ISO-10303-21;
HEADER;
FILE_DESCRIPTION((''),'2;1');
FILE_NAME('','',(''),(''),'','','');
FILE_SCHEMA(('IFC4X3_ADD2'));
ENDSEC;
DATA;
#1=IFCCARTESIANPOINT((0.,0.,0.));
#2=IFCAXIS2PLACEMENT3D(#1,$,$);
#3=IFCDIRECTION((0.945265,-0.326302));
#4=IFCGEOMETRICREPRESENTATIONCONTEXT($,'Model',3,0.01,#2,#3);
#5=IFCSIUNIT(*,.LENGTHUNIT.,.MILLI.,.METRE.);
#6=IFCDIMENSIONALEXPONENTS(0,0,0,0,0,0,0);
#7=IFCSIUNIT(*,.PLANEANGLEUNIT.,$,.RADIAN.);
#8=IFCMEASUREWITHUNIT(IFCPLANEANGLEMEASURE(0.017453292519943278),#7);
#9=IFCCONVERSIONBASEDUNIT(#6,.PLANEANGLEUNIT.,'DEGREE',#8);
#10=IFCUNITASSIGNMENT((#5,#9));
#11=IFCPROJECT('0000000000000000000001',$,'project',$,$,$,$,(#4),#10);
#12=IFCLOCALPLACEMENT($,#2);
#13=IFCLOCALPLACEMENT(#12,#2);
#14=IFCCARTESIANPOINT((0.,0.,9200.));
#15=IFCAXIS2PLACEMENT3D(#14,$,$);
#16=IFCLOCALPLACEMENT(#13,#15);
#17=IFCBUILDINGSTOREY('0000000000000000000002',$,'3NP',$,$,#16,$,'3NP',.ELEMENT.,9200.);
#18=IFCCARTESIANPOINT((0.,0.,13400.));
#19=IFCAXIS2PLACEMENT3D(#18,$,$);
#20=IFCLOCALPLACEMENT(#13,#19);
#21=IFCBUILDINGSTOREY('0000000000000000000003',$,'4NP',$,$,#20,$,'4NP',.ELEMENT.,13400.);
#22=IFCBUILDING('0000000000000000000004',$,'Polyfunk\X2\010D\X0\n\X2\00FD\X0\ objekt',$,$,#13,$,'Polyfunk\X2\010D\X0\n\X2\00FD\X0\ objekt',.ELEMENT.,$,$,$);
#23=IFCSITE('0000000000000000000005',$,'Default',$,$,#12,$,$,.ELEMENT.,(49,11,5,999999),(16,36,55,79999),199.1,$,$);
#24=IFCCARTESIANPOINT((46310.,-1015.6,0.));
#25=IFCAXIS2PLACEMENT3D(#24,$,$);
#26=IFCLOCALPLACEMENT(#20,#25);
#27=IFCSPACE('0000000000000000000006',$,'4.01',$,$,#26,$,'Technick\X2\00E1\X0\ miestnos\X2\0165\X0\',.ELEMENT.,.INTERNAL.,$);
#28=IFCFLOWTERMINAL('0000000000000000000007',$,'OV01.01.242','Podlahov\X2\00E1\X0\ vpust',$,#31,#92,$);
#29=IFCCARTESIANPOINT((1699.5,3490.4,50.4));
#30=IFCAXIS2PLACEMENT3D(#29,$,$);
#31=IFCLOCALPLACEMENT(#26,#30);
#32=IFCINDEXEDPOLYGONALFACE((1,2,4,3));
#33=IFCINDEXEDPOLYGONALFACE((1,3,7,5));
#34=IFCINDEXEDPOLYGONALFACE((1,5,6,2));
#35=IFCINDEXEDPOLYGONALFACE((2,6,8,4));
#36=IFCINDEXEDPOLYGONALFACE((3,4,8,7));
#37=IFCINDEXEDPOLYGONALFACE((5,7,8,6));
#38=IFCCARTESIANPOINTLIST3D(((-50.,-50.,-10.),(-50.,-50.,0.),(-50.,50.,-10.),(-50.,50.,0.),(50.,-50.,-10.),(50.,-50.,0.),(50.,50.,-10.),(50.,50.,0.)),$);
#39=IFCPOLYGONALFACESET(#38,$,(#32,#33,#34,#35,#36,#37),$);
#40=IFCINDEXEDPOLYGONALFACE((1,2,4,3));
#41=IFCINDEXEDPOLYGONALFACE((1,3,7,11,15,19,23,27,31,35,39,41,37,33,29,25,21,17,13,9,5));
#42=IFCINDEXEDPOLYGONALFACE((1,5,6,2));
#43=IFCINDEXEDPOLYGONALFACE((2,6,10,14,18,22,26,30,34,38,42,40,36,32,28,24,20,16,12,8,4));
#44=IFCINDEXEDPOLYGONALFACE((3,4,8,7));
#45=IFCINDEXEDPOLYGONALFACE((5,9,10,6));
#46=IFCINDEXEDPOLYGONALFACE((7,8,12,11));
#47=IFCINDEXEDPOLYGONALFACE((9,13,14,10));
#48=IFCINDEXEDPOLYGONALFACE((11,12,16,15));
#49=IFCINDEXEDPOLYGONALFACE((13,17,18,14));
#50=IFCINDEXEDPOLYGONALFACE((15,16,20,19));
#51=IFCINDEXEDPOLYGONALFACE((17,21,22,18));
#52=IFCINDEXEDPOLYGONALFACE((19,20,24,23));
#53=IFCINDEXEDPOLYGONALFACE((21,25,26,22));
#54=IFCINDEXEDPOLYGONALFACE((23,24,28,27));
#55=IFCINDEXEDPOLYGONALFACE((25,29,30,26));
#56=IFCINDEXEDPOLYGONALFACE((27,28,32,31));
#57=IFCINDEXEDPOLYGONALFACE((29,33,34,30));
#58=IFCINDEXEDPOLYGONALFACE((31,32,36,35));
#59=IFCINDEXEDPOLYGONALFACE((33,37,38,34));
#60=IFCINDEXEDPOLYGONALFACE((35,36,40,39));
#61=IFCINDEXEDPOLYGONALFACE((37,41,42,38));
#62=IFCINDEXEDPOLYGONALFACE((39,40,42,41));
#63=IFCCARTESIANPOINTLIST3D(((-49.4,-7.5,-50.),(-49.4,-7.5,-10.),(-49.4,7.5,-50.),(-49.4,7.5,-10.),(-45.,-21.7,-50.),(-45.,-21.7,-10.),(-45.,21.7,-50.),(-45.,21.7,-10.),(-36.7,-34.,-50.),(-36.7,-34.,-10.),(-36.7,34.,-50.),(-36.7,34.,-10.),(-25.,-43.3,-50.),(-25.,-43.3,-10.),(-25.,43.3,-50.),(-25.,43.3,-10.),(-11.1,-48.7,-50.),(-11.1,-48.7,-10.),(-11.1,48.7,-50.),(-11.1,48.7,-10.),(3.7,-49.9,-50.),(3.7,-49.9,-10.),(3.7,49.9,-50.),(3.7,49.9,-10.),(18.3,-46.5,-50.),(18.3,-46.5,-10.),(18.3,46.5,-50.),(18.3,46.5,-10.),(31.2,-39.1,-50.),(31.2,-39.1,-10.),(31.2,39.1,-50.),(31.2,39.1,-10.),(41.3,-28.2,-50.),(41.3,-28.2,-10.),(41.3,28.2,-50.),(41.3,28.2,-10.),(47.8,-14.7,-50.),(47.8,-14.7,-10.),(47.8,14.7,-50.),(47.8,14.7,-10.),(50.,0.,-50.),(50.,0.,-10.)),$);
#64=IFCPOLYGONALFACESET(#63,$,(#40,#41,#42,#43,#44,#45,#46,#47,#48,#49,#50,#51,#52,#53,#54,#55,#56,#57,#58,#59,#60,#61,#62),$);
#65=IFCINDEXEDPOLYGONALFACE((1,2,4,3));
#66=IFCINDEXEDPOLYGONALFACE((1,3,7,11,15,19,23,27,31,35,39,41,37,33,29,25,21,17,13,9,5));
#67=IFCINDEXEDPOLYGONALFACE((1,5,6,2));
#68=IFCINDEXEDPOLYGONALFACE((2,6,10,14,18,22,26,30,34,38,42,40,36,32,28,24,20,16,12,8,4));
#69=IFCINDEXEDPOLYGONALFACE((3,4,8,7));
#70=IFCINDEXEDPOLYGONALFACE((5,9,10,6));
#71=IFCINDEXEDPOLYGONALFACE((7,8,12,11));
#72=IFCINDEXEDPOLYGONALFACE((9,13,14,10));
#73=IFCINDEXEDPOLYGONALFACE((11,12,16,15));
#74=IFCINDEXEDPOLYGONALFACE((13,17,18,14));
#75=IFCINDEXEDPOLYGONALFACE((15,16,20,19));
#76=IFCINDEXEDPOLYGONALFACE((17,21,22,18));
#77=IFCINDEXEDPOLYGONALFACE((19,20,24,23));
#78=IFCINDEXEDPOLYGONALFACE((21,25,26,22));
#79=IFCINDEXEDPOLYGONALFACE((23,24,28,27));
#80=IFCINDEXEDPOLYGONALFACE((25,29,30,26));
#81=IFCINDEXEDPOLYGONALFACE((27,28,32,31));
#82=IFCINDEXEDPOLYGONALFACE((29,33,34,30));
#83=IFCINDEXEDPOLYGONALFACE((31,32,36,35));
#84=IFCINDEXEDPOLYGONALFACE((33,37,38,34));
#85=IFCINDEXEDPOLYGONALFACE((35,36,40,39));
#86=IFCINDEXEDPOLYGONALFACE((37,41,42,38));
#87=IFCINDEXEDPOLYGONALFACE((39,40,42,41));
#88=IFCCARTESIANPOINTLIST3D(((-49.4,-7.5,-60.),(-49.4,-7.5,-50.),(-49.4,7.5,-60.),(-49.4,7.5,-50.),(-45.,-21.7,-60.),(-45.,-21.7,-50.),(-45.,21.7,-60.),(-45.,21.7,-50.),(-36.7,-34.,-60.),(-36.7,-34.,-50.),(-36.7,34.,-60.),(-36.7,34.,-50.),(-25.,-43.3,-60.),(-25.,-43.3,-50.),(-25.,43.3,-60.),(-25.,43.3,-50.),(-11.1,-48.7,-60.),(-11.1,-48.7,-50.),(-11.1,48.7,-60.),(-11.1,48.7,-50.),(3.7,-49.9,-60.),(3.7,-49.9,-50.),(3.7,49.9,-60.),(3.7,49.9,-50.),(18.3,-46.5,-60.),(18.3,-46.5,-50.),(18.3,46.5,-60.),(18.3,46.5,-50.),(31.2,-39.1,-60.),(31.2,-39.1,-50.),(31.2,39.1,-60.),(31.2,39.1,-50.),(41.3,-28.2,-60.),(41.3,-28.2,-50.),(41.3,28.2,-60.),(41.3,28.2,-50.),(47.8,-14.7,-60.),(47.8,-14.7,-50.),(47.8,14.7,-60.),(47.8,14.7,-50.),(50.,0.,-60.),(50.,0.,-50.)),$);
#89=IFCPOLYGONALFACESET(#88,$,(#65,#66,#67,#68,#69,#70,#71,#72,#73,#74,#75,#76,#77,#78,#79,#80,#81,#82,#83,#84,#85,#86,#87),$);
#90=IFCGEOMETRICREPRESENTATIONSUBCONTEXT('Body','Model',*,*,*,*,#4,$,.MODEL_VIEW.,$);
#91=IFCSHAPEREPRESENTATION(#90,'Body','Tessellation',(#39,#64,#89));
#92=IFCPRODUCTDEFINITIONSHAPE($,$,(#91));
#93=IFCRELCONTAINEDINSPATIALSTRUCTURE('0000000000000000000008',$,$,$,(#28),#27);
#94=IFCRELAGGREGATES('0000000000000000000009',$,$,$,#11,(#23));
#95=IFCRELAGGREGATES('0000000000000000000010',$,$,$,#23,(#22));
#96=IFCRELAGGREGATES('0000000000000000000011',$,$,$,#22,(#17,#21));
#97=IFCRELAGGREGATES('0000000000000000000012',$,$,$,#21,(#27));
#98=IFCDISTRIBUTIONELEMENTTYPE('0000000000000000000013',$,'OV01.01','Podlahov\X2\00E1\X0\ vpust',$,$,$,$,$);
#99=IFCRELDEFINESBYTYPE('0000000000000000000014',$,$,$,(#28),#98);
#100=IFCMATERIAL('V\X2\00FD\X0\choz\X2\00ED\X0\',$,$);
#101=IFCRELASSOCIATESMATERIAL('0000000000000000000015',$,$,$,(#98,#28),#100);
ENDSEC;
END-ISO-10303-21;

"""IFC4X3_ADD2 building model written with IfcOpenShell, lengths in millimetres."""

from ifc_helpers import new_model, entity, si_unit, converted_unit, direction, frame, frame_2d, origin, place, context, subcontext, project, spatial, rectangle, circle, extrude, source, transform, mapped, material, type_object, type_shapes, element, save


model = new_model("IFC4X3_ADD2")

# Units and contexts
model_context = context("Model", 3, precision=0.01, world=origin(), true_north=direction((0.945265, -0.326302)))
body_context = subcontext(model_context, "Body", "Model", "MODEL_VIEW")
ifc_project = project(units=[si_unit("LENGTHUNIT", "METRE", prefix="MILLI"), converted_unit("PLANEANGLEUNIT", "DEGREE", entity("IfcPlaneAngleMeasure", 0.017453292519943278), si_unit("PLANEANGLEUNIT", "RADIAN"), dimensions=[0, 0, 0, 0, 0, 0, 0])], contexts=[model_context])

# Site, building, storey
site_placement = place(None, origin())
site = spatial("IfcSite", under=ifc_project, at=site_placement, Name="Default", CompositionType="ELEMENT", RefLatitude=(49, 11, 5, 999999), RefLongitude=(16, 36, 55, 79999), RefElevation=199.1)
building_placement = place(site_placement, origin())
building = spatial("IfcBuilding", under=site, at=building_placement, Name="Polyfunkčný objekt", LongName="Polyfunkčný objekt", CompositionType="ELEMENT")
storey_1_placement = place(building_placement, frame((0.0, 0.0, 9200.0)))
storey_1 = spatial("IfcBuildingStorey", under=building, at=storey_1_placement, Name="3NP", LongName="3NP", CompositionType="ELEMENT", Elevation=9200.0)

# Shared definitions
storey_2_placement = place(building_placement, frame((0.0, 0.0, 13400.0)))
storey_2 = spatial("IfcBuildingStorey", under=building, at=storey_2_placement, Name="4NP", LongName="4NP", CompositionType="ELEMENT", Elevation=13400.0)

# Shared definitions
space_placement = place(storey_2_placement, frame((46310.0, -1015.6, 0.0)))
space = spatial("IfcSpace", under=storey_2, at=space_placement, Name="4.01", LongName="Technická miestnosť", CompositionType="ELEMENT", PredefinedType="INTERNAL")

# Flow terminal
ifc_material_1 = material(Name="Výchozí")
distribution_element_type = type_object("IfcDistributionElementType", Name="OV01.01", Description="Podlahová vpust", material=ifc_material_1)
shared_shape_1 = source(origin(), body_context, "Body", "SweptSolid", [
    extrude(rectangle(XDim=100.0, YDim=100.0, at=frame_2d((0.0, 0.0), x_axis=(1.0, 0.0))), frame((0.0, 0.0, -10.0), z_axis=(0.0, 0.0, 1.0), x_axis=(-1.0, 0.0, 0.0)), (0.0, 0.0, 1.0), 10.0),
    extrude(circle(Radius=50.0, at=frame_2d((0.0, 0.0), x_axis=(1.0, 0.0))), frame((0.0, 0.0, -50.0)), (0.0, 0.0, 1.0), 40.0),
    extrude(circle(Radius=50.0, at=frame_2d((0.0, 0.0), x_axis=(1.0, 0.0))), frame((0.0, 0.0, -60.0)), (0.0, 0.0, 1.0), 10.0),
])
type_shapes(distribution_element_type, [shared_shape_1])
flow_terminal_placement = place(space_placement, frame((1699.5, 3490.4, 50.4)))
element("IfcFlowTerminal", 1, at=flow_terminal_placement, inside=space, type_object=distribution_element_type, material=ifc_material_1, Name="OV01.01.242", Description="Podlahová vpust", context=body_context, shape_type="MappedRepresentation", body=[
    mapped(shared_shape_1, transform((0.0, 0.0, 0.0), scale=1.0)),
])

save(model, "model.ifc")
